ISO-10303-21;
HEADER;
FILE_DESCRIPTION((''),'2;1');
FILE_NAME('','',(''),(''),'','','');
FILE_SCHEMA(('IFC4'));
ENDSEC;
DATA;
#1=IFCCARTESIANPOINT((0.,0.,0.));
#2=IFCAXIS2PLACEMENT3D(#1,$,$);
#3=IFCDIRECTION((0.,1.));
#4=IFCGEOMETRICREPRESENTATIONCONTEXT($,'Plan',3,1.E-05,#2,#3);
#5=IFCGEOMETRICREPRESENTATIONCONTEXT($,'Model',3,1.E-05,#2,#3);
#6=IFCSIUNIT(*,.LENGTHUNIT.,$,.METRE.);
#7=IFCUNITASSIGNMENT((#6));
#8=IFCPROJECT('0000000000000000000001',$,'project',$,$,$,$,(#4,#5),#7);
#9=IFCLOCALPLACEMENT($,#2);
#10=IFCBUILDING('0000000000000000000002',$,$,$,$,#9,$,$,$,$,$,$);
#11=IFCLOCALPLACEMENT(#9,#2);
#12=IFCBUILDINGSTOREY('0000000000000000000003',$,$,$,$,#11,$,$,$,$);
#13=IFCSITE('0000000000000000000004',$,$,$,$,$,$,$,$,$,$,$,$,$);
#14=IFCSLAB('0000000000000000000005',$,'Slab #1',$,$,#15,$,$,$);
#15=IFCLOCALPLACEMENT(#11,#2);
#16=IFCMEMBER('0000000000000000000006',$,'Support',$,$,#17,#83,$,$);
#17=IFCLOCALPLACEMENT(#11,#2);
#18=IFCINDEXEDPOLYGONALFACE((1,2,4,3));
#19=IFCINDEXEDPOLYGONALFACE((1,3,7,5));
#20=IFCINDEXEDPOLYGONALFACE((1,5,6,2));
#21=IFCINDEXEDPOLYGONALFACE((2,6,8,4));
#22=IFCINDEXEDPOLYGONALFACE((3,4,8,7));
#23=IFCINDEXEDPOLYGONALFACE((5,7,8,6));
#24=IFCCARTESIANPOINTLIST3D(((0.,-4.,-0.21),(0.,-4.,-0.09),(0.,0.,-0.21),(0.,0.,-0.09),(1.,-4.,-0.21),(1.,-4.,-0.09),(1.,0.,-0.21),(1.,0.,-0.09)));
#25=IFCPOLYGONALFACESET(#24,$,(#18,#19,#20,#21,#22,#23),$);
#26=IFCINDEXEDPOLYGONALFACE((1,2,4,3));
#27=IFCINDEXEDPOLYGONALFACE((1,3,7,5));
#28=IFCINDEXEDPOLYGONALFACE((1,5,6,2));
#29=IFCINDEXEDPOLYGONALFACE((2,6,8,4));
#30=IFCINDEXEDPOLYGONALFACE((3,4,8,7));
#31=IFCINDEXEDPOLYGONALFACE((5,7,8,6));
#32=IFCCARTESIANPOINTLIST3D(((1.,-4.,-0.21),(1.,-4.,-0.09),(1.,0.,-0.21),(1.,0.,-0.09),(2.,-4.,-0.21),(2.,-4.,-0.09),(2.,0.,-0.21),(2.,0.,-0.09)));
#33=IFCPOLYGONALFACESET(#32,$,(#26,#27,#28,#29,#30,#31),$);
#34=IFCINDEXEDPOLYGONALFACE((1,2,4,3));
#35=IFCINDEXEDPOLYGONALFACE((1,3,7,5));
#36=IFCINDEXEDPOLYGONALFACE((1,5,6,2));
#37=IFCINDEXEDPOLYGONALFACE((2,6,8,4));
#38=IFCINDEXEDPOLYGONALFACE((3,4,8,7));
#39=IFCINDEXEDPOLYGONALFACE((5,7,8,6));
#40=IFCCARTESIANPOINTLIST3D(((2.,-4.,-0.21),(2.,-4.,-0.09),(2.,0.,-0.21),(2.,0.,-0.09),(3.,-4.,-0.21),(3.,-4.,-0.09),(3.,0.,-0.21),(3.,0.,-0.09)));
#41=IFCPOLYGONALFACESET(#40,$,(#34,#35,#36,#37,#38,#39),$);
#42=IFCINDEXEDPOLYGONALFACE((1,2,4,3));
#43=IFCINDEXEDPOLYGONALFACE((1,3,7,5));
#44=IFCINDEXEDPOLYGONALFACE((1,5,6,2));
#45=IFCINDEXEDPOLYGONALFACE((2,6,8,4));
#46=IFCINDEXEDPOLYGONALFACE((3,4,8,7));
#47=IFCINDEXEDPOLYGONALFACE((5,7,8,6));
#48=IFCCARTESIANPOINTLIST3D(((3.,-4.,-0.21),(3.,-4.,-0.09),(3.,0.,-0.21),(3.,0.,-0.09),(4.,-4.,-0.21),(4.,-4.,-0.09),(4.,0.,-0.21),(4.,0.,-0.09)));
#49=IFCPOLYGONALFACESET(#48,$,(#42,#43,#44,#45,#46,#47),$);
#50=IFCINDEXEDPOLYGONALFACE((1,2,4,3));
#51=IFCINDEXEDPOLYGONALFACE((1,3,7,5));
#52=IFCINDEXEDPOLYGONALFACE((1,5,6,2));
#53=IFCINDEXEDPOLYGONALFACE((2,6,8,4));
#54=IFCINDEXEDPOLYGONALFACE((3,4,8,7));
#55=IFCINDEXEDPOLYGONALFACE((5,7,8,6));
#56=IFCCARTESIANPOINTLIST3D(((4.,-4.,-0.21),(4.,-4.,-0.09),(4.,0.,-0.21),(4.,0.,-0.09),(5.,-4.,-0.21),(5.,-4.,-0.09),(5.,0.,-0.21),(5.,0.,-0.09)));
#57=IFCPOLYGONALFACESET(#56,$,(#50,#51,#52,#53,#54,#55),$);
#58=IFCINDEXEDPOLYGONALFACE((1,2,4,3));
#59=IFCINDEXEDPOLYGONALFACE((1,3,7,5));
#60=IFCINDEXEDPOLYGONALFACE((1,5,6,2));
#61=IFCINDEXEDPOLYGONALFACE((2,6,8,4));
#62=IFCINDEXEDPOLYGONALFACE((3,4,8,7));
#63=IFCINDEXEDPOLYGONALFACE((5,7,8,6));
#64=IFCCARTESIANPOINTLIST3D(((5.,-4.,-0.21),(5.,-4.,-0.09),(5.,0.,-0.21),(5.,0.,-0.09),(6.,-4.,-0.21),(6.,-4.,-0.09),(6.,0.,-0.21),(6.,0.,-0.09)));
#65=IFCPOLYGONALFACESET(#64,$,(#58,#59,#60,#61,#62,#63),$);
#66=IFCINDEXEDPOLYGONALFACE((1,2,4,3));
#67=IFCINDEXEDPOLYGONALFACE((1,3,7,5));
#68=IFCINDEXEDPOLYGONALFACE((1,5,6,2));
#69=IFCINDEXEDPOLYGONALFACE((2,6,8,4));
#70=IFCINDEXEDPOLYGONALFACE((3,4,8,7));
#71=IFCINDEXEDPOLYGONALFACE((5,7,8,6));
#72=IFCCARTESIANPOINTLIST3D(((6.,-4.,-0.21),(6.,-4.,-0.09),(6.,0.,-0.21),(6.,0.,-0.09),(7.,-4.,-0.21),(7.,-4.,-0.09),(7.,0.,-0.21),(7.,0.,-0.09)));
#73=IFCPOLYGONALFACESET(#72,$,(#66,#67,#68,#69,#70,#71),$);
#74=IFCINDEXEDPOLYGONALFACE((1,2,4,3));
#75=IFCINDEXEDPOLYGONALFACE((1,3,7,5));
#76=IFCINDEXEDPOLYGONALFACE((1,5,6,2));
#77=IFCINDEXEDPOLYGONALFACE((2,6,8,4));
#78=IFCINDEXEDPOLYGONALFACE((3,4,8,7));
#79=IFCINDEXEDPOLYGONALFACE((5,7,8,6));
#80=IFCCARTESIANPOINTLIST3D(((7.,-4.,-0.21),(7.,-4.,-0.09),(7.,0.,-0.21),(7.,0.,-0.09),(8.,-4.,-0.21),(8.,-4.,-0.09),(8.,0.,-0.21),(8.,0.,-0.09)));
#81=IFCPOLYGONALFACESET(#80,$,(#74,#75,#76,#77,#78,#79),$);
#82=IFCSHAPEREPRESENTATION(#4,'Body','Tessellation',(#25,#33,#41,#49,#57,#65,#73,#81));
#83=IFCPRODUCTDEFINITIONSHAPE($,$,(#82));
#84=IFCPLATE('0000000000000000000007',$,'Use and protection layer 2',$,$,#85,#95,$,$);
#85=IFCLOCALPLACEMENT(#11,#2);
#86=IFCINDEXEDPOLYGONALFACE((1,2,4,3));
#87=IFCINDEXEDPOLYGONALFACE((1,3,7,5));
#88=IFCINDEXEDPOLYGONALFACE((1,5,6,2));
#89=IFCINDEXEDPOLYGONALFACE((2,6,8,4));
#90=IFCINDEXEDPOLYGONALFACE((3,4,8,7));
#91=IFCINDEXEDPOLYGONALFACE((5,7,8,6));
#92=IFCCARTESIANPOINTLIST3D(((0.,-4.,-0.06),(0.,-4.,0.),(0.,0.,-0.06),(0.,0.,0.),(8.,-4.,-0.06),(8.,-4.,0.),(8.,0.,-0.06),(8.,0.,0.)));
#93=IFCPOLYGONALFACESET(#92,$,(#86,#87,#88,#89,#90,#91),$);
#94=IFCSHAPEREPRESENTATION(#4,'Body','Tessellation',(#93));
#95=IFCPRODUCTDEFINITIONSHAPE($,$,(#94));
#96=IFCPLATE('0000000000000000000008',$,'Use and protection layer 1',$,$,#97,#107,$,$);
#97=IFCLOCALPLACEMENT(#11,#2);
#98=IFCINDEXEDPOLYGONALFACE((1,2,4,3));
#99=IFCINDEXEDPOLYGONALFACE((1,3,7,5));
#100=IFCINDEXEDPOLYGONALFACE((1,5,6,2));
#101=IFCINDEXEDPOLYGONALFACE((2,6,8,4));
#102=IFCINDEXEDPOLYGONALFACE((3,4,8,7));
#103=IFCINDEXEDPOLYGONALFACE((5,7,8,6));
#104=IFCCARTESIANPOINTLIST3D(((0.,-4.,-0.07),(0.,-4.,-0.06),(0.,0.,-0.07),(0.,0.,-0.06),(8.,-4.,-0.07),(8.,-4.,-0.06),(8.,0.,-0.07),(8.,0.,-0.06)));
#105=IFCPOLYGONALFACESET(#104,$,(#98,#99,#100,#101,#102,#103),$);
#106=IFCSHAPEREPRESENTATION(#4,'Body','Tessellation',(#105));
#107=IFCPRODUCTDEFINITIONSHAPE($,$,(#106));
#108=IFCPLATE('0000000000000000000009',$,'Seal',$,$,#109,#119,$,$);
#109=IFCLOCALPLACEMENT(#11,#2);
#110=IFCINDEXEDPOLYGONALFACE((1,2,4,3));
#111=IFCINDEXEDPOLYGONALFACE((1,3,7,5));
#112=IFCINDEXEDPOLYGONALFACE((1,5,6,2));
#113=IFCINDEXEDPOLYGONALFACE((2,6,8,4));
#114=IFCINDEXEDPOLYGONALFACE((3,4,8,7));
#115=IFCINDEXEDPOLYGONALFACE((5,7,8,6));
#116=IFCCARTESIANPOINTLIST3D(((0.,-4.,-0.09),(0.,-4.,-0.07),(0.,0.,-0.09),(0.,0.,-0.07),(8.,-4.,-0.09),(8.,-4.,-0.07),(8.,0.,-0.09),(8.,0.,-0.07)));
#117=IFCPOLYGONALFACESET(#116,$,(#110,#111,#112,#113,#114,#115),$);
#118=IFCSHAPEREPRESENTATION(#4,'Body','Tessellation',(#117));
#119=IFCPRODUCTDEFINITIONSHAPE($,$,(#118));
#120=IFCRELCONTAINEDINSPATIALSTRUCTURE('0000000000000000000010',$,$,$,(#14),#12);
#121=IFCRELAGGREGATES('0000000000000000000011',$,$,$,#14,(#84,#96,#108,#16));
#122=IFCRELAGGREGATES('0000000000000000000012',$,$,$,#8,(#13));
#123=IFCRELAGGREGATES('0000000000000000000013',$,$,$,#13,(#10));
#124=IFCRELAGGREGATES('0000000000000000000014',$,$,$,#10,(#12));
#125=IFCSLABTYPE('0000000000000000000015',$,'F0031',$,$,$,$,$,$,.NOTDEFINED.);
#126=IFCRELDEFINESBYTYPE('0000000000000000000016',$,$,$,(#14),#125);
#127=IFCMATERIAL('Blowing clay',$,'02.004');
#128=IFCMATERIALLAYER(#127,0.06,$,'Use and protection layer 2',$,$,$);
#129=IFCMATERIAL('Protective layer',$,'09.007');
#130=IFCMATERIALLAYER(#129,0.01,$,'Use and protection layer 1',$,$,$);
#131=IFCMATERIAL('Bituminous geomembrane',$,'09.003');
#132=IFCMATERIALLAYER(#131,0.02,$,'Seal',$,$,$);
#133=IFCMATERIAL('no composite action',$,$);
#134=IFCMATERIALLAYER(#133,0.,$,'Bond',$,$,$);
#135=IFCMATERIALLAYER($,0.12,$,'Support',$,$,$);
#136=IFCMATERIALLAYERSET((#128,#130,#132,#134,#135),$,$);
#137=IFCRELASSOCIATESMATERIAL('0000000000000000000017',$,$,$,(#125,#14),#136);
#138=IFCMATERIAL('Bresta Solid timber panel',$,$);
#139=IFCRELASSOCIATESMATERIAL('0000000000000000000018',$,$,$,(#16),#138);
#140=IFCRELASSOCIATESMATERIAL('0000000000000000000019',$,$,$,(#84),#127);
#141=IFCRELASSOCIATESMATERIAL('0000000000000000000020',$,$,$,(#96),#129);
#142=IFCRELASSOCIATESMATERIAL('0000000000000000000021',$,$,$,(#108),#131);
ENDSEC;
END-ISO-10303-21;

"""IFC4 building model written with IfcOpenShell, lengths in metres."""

from ifc_helpers import new_model, si_unit, direction, frame, frame_2d, origin, origin_with_axes, place, context, project, spatial, rectangle, extrude, material, layer, layer_set, type_object, element, aggregate, save


model = new_model("IFC4")

# Units and contexts
plan_context = context("Plan", 3, precision=1e-05, world=origin(), true_north=direction((0.0, 1.0)))
model_context = context("Model", 3, precision=1e-05, world=origin(), true_north=direction((0.0, 1.0)))
ifc_project = project(units=[si_unit("LENGTHUNIT", "METRE")], contexts=[plan_context, model_context])

# Site, building, storey
site = spatial("IfcSite", under=ifc_project)
building_placement = place(None, origin())
building = spatial("IfcBuilding", under=site, at=building_placement)
storey_placement = place(building_placement, origin())
storey = spatial("IfcBuildingStorey", under=building, at=storey_placement)

# Slab, member, plates
ifc_material_1 = material(Name="Blowing clay", Category="02.004")
ifc_layer_1 = layer(ifc_material_1, 0.06, Name="Use and protection layer 2")
ifc_material_2 = material(Name="Protective layer", Category="09.007")
ifc_layer_2 = layer(ifc_material_2, 0.01, Name="Use and protection layer 1")
ifc_material_3 = material(Name="Bituminous geomembrane", Category="09.003")
ifc_layer_3 = layer(ifc_material_3, 0.02, Name="Seal")
ifc_material_4 = material(Name="no composite action")
ifc_layer_4 = layer(ifc_material_4, 0.0, Name="Bond")
ifc_layer_5 = layer(None, 0.12, Name="Support")
ifc_layer_set = layer_set([ifc_layer_1, ifc_layer_2, ifc_layer_3, ifc_layer_4, ifc_layer_5])
slab_type = type_object("IfcSlabType", Name="F0031", PredefinedType="NOTDEFINED", material=ifc_layer_set)
slab_placement = place(None, frame((0.0, 0.0, 0.0), z_axis=(0.0, 0.0, -1.0), x_axis=(1.0, 0.0, 0.0)))
slab = element("IfcSlab", 1, at=slab_placement, inside=storey, type_object=slab_type, material=ifc_layer_set, Name="Slab #1")
ifc_material_5 = material(Name="Bresta Solid timber panel")
member_placement = place(slab_placement, origin())
member = element("IfcMember", 2, at=member_placement, material=ifc_material_5, Name="Support", context=plan_context, shape_type="SweptSolid", body=[
    extrude(rectangle(XDim=1.0, YDim=0.12, at=frame_2d((0.5, 0.06), x_axis=(1.0, 0.0))), frame((0.0, 4.0, 0.09), z_axis=(0.0, -1.0, 0.0), x_axis=(1.0, 0.0, 0.0)), (0.0, 0.0, 1.0), 4.0),
    extrude(rectangle(XDim=1.0, YDim=0.12, at=frame_2d((0.5, 0.06), x_axis=(1.0, 0.0))), frame((1.0, 4.0, 0.09), z_axis=(0.0, -1.0, 0.0), x_axis=(1.0, 0.0, 0.0)), (0.0, 0.0, 1.0), 4.0),
    extrude(rectangle(XDim=1.0, YDim=0.12, at=frame_2d((0.5, 0.06), x_axis=(1.0, 0.0))), frame((2.0, 4.0, 0.09), z_axis=(0.0, -1.0, 0.0), x_axis=(1.0, 0.0, 0.0)), (0.0, 0.0, 1.0), 4.0),
    extrude(rectangle(XDim=1.0, YDim=0.12, at=frame_2d((0.5, 0.06), x_axis=(1.0, 0.0))), frame((3.0, 4.0, 0.09), z_axis=(0.0, -1.0, 0.0), x_axis=(1.0, 0.0, 0.0)), (0.0, 0.0, 1.0), 4.0),
    extrude(rectangle(XDim=1.0, YDim=0.12, at=frame_2d((0.5, 0.06), x_axis=(1.0, 0.0))), frame((4.0, 4.0, 0.09), z_axis=(0.0, -1.0, 0.0), x_axis=(1.0, 0.0, 0.0)), (0.0, 0.0, 1.0), 4.0),
    extrude(rectangle(XDim=1.0, YDim=0.12, at=frame_2d((0.5, 0.06), x_axis=(1.0, 0.0))), frame((5.0, 4.0, 0.09), z_axis=(0.0, -1.0, 0.0), x_axis=(1.0, 0.0, 0.0)), (0.0, 0.0, 1.0), 4.0),
    extrude(rectangle(XDim=1.0, YDim=0.12, at=frame_2d((0.5, 0.06), x_axis=(1.0, 0.0))), frame((6.0, 4.0, 0.09), z_axis=(0.0, -1.0, 0.0), x_axis=(1.0, 0.0, 0.0)), (0.0, 0.0, 1.0), 4.0),
    extrude(rectangle(XDim=1.0, YDim=0.12, at=frame_2d((0.5, 0.06), x_axis=(1.0, 0.0))), frame((7.0, 4.0, 0.09), z_axis=(0.0, -1.0, 0.0), x_axis=(1.0, 0.0, 0.0)), (0.0, 0.0, 1.0), 4.0),
])
plate_1_placement = place(slab_placement, origin())
plate_1 = element("IfcPlate", 3, at=plate_1_placement, material=ifc_material_1, Name="Use and protection layer 2", context=plan_context, shape_type="SweptSolid", body=[
    extrude(rectangle(XDim=8.0, YDim=4.0, at=frame_2d((4.0, 2.0), x_axis=(1.0, 0.0))), origin_with_axes(), (0.0, 0.0, 1.0), 0.06),
])
plate_2_placement = place(slab_placement, origin())
plate_2 = element("IfcPlate", 4, at=plate_2_placement, material=ifc_material_2, Name="Use and protection layer 1", context=plan_context, shape_type="SweptSolid", body=[
    extrude(rectangle(XDim=8.0, YDim=4.0, at=frame_2d((4.0, 2.0), x_axis=(1.0, 0.0))), frame((0.0, 0.0, 0.06), z_axis=(0.0, 0.0, 1.0), x_axis=(1.0, 0.0, 0.0)), (0.0, 0.0, 1.0), 0.01),
])
plate_3_placement = place(slab_placement, origin())
plate_3 = element("IfcPlate", 5, at=plate_3_placement, material=ifc_material_3, Name="Seal", context=plan_context, shape_type="SweptSolid", body=[
    extrude(rectangle(XDim=8.0, YDim=4.0, at=frame_2d((4.0, 2.0), x_axis=(1.0, 0.0))), frame((0.0, 0.0, 0.07), z_axis=(0.0, 0.0, 1.0), x_axis=(1.0, 0.0, 0.0)), (0.0, 0.0, 1.0), 0.02),
])
aggregate(slab, [plate_1, plate_2, plate_3, member])

save(model, "model.ifc")
